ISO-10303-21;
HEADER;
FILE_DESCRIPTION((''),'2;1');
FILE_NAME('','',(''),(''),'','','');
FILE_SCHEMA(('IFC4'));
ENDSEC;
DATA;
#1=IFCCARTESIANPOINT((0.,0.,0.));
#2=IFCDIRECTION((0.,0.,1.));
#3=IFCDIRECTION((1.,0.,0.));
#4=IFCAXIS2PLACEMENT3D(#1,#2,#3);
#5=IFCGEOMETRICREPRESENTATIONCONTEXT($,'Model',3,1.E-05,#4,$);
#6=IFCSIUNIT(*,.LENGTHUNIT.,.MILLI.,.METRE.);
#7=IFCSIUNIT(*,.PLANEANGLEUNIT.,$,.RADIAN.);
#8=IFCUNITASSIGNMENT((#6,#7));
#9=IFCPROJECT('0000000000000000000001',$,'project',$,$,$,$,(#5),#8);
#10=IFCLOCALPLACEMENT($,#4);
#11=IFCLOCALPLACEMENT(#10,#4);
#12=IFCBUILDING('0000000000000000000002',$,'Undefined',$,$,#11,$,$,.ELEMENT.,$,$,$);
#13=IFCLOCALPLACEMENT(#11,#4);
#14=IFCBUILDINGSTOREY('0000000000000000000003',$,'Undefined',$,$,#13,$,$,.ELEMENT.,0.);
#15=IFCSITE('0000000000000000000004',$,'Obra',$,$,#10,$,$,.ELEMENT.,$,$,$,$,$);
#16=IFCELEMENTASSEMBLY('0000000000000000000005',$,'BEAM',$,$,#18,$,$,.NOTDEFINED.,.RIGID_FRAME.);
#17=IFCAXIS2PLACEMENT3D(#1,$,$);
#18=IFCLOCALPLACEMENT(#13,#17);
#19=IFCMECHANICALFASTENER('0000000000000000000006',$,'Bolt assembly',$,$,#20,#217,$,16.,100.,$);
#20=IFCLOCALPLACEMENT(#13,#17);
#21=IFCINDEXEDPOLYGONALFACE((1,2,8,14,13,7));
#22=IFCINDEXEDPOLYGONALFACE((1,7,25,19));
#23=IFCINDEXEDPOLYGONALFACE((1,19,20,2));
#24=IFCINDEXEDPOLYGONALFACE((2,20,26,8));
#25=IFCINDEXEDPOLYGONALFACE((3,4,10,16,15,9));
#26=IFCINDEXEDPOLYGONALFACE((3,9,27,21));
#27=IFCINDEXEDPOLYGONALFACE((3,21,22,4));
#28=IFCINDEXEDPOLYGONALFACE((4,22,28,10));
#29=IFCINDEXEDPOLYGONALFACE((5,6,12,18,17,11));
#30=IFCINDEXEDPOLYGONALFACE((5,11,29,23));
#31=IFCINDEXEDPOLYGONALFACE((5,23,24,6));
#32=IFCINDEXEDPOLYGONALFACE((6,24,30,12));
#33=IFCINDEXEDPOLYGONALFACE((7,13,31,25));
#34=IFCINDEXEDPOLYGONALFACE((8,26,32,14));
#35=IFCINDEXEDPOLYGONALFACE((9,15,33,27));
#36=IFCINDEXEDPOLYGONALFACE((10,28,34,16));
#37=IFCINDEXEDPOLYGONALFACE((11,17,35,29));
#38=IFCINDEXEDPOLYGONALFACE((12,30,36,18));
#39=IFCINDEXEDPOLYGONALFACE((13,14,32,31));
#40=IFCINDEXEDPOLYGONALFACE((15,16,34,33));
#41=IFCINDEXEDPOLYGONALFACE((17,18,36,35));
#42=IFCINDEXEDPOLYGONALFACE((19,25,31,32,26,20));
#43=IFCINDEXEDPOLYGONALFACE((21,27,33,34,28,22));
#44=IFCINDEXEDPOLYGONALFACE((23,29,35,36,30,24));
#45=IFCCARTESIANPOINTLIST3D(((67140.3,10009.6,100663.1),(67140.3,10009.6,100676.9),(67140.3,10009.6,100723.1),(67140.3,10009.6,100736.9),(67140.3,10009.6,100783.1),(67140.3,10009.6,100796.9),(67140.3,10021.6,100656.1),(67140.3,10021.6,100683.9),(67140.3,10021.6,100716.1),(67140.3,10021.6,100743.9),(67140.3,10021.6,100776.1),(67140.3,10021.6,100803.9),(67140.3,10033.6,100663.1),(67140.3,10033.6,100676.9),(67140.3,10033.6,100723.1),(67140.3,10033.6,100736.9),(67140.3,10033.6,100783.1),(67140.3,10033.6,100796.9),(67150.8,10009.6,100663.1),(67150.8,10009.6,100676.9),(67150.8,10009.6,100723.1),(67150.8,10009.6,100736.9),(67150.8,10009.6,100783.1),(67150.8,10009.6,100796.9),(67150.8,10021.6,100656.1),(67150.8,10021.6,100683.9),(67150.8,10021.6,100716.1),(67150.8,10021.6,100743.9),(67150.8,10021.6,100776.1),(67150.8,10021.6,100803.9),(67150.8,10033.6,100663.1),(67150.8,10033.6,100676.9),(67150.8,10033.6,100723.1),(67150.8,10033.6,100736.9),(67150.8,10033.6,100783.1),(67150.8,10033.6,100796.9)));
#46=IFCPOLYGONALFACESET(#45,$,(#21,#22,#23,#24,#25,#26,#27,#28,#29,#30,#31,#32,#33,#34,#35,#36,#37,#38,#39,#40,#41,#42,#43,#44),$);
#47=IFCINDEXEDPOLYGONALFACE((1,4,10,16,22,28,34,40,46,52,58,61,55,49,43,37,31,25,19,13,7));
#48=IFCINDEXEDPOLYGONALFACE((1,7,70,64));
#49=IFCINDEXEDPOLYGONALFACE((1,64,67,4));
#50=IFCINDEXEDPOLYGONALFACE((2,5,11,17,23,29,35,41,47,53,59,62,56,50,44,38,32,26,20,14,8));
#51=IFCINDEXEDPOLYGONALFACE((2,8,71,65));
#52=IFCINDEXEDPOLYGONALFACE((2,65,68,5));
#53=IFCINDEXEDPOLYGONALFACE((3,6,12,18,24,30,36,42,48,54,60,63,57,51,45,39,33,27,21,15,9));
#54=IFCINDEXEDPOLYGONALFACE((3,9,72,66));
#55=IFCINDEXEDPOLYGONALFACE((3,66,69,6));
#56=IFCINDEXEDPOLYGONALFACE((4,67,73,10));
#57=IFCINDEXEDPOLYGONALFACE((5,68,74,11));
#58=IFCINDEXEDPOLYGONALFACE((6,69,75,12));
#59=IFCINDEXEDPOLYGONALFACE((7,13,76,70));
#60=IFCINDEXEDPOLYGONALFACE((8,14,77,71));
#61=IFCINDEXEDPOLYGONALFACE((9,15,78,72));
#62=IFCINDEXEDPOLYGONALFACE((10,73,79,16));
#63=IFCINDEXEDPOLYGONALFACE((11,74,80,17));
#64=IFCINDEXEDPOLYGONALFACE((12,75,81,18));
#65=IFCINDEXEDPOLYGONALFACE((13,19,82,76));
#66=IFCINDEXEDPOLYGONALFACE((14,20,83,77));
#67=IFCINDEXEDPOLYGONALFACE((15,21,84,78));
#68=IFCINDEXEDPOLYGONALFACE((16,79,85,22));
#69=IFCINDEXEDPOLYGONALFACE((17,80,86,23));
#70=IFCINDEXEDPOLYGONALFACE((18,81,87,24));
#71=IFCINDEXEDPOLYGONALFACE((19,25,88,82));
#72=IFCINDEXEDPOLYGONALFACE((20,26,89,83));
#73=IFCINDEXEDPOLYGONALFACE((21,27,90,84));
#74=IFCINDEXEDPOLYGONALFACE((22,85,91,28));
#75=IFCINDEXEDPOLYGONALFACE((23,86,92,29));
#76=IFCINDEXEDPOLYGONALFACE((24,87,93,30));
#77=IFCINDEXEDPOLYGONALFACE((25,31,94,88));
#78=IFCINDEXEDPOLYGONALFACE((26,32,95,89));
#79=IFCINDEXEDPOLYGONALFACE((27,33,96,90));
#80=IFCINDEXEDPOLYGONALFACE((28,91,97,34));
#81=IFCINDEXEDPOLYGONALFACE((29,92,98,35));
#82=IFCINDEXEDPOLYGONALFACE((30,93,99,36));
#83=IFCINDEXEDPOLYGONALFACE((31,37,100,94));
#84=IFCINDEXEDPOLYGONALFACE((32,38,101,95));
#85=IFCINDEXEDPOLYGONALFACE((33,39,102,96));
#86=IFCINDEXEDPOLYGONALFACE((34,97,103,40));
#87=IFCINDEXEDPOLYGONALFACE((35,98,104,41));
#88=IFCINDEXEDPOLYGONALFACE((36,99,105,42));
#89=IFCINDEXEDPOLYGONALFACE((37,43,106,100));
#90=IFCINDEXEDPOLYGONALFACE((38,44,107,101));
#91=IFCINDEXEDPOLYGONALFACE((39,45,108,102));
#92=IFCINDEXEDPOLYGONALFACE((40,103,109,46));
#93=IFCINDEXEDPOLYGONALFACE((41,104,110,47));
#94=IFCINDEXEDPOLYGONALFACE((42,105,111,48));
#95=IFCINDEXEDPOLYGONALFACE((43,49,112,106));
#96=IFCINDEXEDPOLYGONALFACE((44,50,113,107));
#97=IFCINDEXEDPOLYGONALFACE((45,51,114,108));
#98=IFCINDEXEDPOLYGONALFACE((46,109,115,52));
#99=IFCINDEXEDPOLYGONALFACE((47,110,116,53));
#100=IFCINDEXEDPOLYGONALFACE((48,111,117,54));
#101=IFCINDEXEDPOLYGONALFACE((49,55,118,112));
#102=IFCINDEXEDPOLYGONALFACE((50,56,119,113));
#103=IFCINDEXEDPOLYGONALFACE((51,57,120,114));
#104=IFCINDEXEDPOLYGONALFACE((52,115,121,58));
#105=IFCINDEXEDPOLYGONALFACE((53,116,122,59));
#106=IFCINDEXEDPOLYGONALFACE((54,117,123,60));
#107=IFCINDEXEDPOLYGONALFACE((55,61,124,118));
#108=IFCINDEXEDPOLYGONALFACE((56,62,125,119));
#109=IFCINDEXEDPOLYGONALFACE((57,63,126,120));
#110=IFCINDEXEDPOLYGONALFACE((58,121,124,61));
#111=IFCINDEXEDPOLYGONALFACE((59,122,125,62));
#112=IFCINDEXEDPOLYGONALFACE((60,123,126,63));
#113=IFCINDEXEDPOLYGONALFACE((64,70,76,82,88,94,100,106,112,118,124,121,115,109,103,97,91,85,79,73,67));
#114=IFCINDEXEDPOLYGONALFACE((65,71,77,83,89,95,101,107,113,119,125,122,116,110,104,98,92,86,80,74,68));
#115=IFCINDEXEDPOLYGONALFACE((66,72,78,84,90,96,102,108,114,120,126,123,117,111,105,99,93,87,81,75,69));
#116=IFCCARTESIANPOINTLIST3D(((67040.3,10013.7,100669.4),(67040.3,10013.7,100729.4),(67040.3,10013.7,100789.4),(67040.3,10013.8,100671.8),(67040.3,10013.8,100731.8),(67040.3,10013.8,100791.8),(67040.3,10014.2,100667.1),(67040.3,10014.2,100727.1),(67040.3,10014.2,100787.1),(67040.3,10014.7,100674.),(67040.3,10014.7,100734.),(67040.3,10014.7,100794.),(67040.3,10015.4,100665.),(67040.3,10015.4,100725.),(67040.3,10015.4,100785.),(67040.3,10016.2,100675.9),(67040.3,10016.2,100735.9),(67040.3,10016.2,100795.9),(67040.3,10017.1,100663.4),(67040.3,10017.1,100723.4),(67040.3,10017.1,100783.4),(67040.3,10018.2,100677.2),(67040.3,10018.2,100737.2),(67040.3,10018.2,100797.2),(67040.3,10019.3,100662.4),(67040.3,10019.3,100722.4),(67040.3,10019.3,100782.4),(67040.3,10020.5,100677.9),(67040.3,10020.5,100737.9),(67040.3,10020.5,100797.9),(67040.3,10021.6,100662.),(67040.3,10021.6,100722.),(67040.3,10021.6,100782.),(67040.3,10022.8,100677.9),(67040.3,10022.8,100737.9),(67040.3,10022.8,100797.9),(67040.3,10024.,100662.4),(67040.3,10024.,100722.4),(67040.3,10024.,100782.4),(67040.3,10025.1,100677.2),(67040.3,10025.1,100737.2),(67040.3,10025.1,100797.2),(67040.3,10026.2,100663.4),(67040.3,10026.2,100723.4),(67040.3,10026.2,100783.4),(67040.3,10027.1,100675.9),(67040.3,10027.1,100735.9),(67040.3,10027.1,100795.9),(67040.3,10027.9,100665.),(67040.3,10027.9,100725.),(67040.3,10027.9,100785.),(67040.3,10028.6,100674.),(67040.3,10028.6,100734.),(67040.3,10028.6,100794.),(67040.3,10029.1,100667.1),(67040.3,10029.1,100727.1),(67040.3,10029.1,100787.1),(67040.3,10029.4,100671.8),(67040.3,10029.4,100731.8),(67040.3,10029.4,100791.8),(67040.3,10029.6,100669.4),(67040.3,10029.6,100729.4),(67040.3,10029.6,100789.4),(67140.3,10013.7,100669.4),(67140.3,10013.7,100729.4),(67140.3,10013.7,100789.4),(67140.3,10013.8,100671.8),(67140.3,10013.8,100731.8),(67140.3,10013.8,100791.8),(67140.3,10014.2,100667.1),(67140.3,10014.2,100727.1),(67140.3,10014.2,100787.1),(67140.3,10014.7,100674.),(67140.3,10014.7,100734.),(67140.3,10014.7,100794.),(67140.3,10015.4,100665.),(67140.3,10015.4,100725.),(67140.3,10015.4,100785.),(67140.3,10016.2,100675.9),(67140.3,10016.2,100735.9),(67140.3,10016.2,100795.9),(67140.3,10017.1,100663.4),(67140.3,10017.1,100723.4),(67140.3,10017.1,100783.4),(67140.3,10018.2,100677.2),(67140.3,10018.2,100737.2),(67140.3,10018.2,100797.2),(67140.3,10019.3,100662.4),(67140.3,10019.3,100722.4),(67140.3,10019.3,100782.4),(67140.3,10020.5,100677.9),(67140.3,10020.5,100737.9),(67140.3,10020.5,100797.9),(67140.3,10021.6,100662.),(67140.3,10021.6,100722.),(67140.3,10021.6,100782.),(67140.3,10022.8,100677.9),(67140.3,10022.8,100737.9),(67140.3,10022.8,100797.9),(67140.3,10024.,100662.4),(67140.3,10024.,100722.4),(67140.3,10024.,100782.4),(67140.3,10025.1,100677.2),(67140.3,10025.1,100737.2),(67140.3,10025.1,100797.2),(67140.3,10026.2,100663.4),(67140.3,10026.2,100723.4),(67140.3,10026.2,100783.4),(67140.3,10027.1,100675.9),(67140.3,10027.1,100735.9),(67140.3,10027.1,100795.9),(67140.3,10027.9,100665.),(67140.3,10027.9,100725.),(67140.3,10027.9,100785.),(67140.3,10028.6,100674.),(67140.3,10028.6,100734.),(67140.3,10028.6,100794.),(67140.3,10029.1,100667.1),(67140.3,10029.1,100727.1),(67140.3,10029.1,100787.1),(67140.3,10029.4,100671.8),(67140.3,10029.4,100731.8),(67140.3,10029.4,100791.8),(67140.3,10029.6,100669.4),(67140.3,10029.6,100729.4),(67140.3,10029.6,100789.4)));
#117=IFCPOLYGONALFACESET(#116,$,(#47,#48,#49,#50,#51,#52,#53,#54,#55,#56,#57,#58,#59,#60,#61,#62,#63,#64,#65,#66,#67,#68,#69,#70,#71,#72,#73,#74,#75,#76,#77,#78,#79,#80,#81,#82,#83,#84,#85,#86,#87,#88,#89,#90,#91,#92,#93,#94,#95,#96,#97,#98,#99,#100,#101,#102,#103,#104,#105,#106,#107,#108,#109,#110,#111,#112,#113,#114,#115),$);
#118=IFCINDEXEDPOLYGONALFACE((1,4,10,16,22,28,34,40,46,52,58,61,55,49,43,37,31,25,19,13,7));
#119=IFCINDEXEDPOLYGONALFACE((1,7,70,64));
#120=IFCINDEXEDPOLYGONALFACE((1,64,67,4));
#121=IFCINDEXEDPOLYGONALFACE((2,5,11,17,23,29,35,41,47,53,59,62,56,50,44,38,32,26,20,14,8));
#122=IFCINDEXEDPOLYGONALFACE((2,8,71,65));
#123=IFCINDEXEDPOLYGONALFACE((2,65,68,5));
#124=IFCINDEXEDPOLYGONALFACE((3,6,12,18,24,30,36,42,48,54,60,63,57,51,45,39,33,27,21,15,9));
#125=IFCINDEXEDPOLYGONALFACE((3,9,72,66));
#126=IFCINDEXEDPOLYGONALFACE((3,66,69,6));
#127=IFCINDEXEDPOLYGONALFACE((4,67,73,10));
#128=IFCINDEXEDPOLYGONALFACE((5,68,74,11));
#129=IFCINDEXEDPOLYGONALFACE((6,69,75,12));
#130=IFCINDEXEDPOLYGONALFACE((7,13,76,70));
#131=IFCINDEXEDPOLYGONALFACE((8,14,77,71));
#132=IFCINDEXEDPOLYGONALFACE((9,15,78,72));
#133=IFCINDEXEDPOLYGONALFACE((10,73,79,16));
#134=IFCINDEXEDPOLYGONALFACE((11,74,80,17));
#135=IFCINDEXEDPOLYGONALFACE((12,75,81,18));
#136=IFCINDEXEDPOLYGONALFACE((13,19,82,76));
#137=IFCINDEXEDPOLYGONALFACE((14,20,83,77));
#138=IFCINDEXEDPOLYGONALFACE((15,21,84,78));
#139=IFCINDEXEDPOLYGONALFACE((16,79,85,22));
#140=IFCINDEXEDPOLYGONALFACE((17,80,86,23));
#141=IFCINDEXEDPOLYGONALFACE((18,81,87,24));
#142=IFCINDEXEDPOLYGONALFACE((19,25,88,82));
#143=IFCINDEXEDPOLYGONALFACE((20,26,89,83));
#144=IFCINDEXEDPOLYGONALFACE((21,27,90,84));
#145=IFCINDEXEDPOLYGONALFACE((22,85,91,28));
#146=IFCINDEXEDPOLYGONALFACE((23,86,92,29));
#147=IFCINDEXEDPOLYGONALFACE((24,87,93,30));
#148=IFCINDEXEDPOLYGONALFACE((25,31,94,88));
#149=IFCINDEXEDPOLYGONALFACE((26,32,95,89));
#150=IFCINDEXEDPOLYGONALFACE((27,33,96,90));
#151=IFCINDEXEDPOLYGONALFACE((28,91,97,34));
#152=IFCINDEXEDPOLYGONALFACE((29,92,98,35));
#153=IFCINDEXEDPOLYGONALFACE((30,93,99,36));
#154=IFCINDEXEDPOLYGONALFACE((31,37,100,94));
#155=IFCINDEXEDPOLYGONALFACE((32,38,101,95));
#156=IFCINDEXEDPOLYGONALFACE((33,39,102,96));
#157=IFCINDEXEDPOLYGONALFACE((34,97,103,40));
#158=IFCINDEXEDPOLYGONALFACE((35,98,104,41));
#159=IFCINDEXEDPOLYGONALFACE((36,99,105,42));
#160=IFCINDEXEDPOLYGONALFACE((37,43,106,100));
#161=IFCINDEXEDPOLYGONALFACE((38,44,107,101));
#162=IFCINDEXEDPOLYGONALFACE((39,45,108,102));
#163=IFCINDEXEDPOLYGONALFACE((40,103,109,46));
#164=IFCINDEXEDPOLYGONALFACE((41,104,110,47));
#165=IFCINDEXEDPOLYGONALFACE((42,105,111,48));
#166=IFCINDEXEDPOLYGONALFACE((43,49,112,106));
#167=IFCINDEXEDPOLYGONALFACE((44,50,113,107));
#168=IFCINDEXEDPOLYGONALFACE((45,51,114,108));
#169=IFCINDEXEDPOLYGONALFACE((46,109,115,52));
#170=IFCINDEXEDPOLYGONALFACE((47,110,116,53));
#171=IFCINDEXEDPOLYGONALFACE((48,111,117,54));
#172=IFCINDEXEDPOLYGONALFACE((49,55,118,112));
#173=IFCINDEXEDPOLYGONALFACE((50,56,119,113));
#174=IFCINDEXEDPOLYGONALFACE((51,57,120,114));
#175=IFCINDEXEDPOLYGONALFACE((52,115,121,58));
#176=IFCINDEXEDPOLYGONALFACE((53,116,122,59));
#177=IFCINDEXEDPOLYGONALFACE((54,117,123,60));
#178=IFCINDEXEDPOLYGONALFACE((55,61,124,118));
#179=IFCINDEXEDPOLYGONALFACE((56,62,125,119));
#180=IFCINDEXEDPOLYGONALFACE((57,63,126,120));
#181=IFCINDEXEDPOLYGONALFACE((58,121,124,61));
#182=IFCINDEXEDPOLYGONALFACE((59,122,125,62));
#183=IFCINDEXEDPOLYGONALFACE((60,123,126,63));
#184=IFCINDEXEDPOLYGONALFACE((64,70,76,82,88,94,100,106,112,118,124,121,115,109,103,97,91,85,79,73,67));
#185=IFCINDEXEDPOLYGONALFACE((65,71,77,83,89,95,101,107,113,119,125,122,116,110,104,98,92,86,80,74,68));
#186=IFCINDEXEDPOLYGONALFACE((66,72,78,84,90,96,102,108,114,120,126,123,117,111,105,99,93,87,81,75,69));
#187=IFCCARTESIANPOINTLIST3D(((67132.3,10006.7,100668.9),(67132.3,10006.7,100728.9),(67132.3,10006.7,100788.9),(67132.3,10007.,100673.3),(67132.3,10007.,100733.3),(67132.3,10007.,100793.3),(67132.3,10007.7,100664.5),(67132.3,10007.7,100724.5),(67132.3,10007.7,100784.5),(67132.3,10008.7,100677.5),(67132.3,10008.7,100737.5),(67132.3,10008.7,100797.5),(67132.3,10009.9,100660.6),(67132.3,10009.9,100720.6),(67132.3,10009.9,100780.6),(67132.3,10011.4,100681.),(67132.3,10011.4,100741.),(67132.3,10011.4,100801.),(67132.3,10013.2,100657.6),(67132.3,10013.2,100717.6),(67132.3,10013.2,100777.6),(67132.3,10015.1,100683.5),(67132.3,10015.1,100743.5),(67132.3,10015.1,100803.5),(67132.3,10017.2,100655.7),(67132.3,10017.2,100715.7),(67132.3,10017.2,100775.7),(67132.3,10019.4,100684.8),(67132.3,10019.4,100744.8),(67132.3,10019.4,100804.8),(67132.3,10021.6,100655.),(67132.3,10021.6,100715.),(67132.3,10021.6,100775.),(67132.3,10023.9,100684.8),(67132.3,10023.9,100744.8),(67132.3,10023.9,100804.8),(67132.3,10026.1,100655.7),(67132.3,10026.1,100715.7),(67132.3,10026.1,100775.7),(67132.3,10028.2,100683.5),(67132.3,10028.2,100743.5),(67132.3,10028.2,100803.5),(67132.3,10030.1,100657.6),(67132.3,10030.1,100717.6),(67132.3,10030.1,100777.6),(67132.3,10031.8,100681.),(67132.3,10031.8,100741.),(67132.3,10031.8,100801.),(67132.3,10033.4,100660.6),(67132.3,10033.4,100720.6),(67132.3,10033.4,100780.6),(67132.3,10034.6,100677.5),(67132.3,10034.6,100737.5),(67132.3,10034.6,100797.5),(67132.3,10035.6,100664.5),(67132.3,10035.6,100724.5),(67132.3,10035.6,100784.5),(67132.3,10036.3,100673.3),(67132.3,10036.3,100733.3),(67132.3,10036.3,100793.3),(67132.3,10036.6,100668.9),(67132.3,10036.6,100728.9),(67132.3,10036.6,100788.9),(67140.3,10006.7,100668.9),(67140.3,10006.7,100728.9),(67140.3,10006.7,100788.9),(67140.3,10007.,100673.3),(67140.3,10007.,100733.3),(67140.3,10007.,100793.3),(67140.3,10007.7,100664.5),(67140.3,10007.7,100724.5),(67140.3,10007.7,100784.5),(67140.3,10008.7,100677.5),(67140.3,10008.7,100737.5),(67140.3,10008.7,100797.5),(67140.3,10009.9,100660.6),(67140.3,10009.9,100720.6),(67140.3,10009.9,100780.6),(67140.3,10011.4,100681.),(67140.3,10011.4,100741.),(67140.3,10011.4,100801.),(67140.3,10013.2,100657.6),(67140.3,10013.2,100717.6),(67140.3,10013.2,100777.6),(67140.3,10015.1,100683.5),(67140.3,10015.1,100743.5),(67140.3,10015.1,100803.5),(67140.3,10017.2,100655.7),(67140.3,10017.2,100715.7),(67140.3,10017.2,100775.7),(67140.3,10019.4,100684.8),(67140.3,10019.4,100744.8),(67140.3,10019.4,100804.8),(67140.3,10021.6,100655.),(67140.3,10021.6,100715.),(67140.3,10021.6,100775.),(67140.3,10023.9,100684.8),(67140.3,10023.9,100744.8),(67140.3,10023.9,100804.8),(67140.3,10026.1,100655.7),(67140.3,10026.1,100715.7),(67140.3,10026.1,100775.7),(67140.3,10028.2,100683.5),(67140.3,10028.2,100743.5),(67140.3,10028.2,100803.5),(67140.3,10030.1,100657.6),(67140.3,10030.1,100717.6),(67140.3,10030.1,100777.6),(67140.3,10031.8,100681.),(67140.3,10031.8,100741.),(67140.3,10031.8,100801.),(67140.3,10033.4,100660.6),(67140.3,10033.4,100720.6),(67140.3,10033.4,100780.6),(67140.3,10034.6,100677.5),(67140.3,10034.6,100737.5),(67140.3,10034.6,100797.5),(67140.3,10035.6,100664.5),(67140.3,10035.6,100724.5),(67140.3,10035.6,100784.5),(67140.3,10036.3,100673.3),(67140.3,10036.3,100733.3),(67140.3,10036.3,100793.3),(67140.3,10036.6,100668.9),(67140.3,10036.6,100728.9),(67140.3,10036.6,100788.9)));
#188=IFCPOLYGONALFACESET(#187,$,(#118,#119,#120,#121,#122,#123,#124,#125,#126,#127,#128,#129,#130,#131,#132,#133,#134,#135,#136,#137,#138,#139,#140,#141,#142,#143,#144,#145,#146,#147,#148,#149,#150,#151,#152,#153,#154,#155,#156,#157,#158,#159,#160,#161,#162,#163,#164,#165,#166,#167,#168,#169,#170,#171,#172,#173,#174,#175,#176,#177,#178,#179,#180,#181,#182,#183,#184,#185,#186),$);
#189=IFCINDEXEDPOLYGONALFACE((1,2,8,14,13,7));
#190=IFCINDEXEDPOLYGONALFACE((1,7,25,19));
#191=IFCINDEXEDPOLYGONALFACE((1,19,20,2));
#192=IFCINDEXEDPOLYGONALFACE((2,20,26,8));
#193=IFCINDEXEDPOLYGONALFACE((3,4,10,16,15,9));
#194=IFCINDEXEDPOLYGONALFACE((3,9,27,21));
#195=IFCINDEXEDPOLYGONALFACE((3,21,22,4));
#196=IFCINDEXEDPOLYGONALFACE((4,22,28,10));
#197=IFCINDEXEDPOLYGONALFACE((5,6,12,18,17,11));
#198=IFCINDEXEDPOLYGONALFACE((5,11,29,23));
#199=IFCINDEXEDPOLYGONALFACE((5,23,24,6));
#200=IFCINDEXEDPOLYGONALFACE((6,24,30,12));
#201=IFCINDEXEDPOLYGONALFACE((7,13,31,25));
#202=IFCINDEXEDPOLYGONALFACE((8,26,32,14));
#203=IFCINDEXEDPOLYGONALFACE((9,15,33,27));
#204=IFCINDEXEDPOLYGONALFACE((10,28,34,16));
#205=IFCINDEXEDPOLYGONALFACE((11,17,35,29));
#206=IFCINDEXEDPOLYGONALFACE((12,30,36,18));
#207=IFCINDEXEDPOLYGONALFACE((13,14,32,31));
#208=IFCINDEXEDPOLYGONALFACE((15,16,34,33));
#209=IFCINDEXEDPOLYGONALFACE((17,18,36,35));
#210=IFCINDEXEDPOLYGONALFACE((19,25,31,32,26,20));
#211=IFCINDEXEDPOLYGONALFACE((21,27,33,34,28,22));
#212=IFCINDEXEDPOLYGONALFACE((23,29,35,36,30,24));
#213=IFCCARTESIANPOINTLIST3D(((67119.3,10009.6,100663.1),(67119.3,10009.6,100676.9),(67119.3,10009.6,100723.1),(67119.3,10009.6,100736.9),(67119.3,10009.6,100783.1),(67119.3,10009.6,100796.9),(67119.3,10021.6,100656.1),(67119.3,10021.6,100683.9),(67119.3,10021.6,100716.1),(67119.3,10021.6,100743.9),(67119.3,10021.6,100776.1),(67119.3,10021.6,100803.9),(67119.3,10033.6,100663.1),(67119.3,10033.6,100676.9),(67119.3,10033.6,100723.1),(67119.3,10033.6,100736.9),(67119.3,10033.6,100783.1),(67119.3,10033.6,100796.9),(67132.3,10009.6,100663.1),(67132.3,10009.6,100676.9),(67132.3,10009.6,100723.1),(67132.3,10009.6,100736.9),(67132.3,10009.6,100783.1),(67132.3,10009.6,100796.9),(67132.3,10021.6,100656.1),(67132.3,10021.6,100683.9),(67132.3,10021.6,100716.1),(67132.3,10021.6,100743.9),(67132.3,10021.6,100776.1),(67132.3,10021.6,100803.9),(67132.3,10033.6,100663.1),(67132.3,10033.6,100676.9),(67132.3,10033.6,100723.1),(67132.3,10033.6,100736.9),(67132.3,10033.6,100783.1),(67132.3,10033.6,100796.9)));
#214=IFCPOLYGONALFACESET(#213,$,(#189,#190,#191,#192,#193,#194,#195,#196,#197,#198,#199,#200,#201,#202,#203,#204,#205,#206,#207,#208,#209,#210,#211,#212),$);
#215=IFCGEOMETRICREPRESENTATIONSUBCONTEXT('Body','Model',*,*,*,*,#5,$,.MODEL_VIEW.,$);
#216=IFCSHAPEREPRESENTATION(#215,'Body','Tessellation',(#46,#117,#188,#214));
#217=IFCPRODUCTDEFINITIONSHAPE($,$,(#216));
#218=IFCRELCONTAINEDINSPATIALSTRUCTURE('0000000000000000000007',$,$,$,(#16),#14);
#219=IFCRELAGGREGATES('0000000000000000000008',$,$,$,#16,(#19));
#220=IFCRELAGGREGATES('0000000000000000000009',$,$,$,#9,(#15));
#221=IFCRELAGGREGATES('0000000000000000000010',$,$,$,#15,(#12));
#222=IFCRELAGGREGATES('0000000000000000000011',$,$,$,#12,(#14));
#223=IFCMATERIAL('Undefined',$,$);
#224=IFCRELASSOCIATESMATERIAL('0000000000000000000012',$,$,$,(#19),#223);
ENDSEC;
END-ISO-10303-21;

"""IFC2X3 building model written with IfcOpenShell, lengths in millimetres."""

from ifc_helpers import new_model, si_unit, frame, origin_with_axes, origin_2d_with_axis, place, context, subcontext, project, spatial, polyline, circle, outline, extrude, source, transform, mapped, material, element, aggregate, save


model = new_model("IFC2X3")

# Units and contexts
model_context = context("Model", 3, precision=1e-05, world=origin_with_axes())
body_context = subcontext(model_context, "Body", "Model", "MODEL_VIEW")
ifc_project = project(units=[si_unit("LENGTHUNIT", "METRE", prefix="MILLI"), si_unit("PLANEANGLEUNIT", "RADIAN")], contexts=[model_context])

# Site, building, storey
site_placement = place(None, origin_with_axes())
site = spatial("IfcSite", under=ifc_project, at=site_placement, Name="Obra", CompositionType="ELEMENT")
building_placement = place(site_placement, origin_with_axes())
building = spatial("IfcBuilding", under=site, at=building_placement, Name="Undefined", CompositionType="ELEMENT")
storey_placement = place(building_placement, origin_with_axes())
storey = spatial("IfcBuildingStorey", under=building, at=storey_placement, Name="Undefined", CompositionType="ELEMENT", Elevation=0.0)

# Shared definitions
ifc_material_1 = material(Name="Undefined")

# Element assembly, mechanical fastener
shared_shape_1 = source(origin_with_axes(), body_context, "Body", "SweptSolid", [
    extrude(outline(polyline([(13.9, 0.0), (6.9, 12.0), (-6.9, 12.0), (-13.9, 0.0), (-6.9, -12.0), (6.9, -12.0), (13.9, 0.0)])), frame((0.0, -10.6, 0.0), z_axis=(0.0, 1.0, 0.0), x_axis=(1.0, 0.0, 0.0)), (0.0, 0.0, 1.0), 10.6),
    extrude(circle(Radius=8.0, at=origin_2d_with_axis()), frame((0.0, 0.0, 0.0), z_axis=(0.0, 1.0, 0.0), x_axis=(1.0, 0.0, 0.0)), (0.0, 0.0, 1.0), 100.0),
    extrude(circle(Radius=15.0, at=origin_2d_with_axis()), frame((0.0, 0.0, 0.0), z_axis=(0.0, 1.0, 0.0), x_axis=(1.0, 0.0, 0.0)), (0.0, 0.0, 1.0), 8.0),
    extrude(outline(polyline([(13.9, 0.0), (6.9, 12.0), (-6.9, 12.0), (-13.9, 0.0), (-6.9, -12.0), (6.9, -12.0), (13.9, 0.0)])), frame((0.0, 8.0, 0.0), z_axis=(0.0, 1.0, 0.0), x_axis=(1.0, 0.0, 0.0)), (0.0, 0.0, 1.0), 13.0),
])
assembly_1_placement = place(storey_placement, origin_with_axes())
assembly_1 = element("IfcElementAssembly", 1, at=assembly_1_placement, inside=storey, Name="BEAM", AssemblyPlace="NOTDEFINED", PredefinedType="RIGID_FRAME")
mechanical_fastener_1_placement = place(assembly_1_placement, frame((67140.3, 9971.6, 100850.0), z_axis=(0.0, 1.0, 0.0), x_axis=(0.0, 0.0, -1.0)))
mechanical_fastener_1 = element("IfcMechanicalFastener", 2, at=mechanical_fastener_1_placement, material=ifc_material_1, Name="Bolt assembly", NominalDiameter=16.0, NominalLength=100.0, context=body_context, shape_type="MappedRepresentation", body=[
    mapped(shared_shape_1, transform((60.0, 0.0, 50.0))),
    mapped(shared_shape_1, transform((120.0, 0.0, 50.0))),
    mapped(shared_shape_1, transform((180.0, 0.0, 50.0))),
])
aggregate(assembly_1, [mechanical_fastener_1])

save(model, "model.ifc")
